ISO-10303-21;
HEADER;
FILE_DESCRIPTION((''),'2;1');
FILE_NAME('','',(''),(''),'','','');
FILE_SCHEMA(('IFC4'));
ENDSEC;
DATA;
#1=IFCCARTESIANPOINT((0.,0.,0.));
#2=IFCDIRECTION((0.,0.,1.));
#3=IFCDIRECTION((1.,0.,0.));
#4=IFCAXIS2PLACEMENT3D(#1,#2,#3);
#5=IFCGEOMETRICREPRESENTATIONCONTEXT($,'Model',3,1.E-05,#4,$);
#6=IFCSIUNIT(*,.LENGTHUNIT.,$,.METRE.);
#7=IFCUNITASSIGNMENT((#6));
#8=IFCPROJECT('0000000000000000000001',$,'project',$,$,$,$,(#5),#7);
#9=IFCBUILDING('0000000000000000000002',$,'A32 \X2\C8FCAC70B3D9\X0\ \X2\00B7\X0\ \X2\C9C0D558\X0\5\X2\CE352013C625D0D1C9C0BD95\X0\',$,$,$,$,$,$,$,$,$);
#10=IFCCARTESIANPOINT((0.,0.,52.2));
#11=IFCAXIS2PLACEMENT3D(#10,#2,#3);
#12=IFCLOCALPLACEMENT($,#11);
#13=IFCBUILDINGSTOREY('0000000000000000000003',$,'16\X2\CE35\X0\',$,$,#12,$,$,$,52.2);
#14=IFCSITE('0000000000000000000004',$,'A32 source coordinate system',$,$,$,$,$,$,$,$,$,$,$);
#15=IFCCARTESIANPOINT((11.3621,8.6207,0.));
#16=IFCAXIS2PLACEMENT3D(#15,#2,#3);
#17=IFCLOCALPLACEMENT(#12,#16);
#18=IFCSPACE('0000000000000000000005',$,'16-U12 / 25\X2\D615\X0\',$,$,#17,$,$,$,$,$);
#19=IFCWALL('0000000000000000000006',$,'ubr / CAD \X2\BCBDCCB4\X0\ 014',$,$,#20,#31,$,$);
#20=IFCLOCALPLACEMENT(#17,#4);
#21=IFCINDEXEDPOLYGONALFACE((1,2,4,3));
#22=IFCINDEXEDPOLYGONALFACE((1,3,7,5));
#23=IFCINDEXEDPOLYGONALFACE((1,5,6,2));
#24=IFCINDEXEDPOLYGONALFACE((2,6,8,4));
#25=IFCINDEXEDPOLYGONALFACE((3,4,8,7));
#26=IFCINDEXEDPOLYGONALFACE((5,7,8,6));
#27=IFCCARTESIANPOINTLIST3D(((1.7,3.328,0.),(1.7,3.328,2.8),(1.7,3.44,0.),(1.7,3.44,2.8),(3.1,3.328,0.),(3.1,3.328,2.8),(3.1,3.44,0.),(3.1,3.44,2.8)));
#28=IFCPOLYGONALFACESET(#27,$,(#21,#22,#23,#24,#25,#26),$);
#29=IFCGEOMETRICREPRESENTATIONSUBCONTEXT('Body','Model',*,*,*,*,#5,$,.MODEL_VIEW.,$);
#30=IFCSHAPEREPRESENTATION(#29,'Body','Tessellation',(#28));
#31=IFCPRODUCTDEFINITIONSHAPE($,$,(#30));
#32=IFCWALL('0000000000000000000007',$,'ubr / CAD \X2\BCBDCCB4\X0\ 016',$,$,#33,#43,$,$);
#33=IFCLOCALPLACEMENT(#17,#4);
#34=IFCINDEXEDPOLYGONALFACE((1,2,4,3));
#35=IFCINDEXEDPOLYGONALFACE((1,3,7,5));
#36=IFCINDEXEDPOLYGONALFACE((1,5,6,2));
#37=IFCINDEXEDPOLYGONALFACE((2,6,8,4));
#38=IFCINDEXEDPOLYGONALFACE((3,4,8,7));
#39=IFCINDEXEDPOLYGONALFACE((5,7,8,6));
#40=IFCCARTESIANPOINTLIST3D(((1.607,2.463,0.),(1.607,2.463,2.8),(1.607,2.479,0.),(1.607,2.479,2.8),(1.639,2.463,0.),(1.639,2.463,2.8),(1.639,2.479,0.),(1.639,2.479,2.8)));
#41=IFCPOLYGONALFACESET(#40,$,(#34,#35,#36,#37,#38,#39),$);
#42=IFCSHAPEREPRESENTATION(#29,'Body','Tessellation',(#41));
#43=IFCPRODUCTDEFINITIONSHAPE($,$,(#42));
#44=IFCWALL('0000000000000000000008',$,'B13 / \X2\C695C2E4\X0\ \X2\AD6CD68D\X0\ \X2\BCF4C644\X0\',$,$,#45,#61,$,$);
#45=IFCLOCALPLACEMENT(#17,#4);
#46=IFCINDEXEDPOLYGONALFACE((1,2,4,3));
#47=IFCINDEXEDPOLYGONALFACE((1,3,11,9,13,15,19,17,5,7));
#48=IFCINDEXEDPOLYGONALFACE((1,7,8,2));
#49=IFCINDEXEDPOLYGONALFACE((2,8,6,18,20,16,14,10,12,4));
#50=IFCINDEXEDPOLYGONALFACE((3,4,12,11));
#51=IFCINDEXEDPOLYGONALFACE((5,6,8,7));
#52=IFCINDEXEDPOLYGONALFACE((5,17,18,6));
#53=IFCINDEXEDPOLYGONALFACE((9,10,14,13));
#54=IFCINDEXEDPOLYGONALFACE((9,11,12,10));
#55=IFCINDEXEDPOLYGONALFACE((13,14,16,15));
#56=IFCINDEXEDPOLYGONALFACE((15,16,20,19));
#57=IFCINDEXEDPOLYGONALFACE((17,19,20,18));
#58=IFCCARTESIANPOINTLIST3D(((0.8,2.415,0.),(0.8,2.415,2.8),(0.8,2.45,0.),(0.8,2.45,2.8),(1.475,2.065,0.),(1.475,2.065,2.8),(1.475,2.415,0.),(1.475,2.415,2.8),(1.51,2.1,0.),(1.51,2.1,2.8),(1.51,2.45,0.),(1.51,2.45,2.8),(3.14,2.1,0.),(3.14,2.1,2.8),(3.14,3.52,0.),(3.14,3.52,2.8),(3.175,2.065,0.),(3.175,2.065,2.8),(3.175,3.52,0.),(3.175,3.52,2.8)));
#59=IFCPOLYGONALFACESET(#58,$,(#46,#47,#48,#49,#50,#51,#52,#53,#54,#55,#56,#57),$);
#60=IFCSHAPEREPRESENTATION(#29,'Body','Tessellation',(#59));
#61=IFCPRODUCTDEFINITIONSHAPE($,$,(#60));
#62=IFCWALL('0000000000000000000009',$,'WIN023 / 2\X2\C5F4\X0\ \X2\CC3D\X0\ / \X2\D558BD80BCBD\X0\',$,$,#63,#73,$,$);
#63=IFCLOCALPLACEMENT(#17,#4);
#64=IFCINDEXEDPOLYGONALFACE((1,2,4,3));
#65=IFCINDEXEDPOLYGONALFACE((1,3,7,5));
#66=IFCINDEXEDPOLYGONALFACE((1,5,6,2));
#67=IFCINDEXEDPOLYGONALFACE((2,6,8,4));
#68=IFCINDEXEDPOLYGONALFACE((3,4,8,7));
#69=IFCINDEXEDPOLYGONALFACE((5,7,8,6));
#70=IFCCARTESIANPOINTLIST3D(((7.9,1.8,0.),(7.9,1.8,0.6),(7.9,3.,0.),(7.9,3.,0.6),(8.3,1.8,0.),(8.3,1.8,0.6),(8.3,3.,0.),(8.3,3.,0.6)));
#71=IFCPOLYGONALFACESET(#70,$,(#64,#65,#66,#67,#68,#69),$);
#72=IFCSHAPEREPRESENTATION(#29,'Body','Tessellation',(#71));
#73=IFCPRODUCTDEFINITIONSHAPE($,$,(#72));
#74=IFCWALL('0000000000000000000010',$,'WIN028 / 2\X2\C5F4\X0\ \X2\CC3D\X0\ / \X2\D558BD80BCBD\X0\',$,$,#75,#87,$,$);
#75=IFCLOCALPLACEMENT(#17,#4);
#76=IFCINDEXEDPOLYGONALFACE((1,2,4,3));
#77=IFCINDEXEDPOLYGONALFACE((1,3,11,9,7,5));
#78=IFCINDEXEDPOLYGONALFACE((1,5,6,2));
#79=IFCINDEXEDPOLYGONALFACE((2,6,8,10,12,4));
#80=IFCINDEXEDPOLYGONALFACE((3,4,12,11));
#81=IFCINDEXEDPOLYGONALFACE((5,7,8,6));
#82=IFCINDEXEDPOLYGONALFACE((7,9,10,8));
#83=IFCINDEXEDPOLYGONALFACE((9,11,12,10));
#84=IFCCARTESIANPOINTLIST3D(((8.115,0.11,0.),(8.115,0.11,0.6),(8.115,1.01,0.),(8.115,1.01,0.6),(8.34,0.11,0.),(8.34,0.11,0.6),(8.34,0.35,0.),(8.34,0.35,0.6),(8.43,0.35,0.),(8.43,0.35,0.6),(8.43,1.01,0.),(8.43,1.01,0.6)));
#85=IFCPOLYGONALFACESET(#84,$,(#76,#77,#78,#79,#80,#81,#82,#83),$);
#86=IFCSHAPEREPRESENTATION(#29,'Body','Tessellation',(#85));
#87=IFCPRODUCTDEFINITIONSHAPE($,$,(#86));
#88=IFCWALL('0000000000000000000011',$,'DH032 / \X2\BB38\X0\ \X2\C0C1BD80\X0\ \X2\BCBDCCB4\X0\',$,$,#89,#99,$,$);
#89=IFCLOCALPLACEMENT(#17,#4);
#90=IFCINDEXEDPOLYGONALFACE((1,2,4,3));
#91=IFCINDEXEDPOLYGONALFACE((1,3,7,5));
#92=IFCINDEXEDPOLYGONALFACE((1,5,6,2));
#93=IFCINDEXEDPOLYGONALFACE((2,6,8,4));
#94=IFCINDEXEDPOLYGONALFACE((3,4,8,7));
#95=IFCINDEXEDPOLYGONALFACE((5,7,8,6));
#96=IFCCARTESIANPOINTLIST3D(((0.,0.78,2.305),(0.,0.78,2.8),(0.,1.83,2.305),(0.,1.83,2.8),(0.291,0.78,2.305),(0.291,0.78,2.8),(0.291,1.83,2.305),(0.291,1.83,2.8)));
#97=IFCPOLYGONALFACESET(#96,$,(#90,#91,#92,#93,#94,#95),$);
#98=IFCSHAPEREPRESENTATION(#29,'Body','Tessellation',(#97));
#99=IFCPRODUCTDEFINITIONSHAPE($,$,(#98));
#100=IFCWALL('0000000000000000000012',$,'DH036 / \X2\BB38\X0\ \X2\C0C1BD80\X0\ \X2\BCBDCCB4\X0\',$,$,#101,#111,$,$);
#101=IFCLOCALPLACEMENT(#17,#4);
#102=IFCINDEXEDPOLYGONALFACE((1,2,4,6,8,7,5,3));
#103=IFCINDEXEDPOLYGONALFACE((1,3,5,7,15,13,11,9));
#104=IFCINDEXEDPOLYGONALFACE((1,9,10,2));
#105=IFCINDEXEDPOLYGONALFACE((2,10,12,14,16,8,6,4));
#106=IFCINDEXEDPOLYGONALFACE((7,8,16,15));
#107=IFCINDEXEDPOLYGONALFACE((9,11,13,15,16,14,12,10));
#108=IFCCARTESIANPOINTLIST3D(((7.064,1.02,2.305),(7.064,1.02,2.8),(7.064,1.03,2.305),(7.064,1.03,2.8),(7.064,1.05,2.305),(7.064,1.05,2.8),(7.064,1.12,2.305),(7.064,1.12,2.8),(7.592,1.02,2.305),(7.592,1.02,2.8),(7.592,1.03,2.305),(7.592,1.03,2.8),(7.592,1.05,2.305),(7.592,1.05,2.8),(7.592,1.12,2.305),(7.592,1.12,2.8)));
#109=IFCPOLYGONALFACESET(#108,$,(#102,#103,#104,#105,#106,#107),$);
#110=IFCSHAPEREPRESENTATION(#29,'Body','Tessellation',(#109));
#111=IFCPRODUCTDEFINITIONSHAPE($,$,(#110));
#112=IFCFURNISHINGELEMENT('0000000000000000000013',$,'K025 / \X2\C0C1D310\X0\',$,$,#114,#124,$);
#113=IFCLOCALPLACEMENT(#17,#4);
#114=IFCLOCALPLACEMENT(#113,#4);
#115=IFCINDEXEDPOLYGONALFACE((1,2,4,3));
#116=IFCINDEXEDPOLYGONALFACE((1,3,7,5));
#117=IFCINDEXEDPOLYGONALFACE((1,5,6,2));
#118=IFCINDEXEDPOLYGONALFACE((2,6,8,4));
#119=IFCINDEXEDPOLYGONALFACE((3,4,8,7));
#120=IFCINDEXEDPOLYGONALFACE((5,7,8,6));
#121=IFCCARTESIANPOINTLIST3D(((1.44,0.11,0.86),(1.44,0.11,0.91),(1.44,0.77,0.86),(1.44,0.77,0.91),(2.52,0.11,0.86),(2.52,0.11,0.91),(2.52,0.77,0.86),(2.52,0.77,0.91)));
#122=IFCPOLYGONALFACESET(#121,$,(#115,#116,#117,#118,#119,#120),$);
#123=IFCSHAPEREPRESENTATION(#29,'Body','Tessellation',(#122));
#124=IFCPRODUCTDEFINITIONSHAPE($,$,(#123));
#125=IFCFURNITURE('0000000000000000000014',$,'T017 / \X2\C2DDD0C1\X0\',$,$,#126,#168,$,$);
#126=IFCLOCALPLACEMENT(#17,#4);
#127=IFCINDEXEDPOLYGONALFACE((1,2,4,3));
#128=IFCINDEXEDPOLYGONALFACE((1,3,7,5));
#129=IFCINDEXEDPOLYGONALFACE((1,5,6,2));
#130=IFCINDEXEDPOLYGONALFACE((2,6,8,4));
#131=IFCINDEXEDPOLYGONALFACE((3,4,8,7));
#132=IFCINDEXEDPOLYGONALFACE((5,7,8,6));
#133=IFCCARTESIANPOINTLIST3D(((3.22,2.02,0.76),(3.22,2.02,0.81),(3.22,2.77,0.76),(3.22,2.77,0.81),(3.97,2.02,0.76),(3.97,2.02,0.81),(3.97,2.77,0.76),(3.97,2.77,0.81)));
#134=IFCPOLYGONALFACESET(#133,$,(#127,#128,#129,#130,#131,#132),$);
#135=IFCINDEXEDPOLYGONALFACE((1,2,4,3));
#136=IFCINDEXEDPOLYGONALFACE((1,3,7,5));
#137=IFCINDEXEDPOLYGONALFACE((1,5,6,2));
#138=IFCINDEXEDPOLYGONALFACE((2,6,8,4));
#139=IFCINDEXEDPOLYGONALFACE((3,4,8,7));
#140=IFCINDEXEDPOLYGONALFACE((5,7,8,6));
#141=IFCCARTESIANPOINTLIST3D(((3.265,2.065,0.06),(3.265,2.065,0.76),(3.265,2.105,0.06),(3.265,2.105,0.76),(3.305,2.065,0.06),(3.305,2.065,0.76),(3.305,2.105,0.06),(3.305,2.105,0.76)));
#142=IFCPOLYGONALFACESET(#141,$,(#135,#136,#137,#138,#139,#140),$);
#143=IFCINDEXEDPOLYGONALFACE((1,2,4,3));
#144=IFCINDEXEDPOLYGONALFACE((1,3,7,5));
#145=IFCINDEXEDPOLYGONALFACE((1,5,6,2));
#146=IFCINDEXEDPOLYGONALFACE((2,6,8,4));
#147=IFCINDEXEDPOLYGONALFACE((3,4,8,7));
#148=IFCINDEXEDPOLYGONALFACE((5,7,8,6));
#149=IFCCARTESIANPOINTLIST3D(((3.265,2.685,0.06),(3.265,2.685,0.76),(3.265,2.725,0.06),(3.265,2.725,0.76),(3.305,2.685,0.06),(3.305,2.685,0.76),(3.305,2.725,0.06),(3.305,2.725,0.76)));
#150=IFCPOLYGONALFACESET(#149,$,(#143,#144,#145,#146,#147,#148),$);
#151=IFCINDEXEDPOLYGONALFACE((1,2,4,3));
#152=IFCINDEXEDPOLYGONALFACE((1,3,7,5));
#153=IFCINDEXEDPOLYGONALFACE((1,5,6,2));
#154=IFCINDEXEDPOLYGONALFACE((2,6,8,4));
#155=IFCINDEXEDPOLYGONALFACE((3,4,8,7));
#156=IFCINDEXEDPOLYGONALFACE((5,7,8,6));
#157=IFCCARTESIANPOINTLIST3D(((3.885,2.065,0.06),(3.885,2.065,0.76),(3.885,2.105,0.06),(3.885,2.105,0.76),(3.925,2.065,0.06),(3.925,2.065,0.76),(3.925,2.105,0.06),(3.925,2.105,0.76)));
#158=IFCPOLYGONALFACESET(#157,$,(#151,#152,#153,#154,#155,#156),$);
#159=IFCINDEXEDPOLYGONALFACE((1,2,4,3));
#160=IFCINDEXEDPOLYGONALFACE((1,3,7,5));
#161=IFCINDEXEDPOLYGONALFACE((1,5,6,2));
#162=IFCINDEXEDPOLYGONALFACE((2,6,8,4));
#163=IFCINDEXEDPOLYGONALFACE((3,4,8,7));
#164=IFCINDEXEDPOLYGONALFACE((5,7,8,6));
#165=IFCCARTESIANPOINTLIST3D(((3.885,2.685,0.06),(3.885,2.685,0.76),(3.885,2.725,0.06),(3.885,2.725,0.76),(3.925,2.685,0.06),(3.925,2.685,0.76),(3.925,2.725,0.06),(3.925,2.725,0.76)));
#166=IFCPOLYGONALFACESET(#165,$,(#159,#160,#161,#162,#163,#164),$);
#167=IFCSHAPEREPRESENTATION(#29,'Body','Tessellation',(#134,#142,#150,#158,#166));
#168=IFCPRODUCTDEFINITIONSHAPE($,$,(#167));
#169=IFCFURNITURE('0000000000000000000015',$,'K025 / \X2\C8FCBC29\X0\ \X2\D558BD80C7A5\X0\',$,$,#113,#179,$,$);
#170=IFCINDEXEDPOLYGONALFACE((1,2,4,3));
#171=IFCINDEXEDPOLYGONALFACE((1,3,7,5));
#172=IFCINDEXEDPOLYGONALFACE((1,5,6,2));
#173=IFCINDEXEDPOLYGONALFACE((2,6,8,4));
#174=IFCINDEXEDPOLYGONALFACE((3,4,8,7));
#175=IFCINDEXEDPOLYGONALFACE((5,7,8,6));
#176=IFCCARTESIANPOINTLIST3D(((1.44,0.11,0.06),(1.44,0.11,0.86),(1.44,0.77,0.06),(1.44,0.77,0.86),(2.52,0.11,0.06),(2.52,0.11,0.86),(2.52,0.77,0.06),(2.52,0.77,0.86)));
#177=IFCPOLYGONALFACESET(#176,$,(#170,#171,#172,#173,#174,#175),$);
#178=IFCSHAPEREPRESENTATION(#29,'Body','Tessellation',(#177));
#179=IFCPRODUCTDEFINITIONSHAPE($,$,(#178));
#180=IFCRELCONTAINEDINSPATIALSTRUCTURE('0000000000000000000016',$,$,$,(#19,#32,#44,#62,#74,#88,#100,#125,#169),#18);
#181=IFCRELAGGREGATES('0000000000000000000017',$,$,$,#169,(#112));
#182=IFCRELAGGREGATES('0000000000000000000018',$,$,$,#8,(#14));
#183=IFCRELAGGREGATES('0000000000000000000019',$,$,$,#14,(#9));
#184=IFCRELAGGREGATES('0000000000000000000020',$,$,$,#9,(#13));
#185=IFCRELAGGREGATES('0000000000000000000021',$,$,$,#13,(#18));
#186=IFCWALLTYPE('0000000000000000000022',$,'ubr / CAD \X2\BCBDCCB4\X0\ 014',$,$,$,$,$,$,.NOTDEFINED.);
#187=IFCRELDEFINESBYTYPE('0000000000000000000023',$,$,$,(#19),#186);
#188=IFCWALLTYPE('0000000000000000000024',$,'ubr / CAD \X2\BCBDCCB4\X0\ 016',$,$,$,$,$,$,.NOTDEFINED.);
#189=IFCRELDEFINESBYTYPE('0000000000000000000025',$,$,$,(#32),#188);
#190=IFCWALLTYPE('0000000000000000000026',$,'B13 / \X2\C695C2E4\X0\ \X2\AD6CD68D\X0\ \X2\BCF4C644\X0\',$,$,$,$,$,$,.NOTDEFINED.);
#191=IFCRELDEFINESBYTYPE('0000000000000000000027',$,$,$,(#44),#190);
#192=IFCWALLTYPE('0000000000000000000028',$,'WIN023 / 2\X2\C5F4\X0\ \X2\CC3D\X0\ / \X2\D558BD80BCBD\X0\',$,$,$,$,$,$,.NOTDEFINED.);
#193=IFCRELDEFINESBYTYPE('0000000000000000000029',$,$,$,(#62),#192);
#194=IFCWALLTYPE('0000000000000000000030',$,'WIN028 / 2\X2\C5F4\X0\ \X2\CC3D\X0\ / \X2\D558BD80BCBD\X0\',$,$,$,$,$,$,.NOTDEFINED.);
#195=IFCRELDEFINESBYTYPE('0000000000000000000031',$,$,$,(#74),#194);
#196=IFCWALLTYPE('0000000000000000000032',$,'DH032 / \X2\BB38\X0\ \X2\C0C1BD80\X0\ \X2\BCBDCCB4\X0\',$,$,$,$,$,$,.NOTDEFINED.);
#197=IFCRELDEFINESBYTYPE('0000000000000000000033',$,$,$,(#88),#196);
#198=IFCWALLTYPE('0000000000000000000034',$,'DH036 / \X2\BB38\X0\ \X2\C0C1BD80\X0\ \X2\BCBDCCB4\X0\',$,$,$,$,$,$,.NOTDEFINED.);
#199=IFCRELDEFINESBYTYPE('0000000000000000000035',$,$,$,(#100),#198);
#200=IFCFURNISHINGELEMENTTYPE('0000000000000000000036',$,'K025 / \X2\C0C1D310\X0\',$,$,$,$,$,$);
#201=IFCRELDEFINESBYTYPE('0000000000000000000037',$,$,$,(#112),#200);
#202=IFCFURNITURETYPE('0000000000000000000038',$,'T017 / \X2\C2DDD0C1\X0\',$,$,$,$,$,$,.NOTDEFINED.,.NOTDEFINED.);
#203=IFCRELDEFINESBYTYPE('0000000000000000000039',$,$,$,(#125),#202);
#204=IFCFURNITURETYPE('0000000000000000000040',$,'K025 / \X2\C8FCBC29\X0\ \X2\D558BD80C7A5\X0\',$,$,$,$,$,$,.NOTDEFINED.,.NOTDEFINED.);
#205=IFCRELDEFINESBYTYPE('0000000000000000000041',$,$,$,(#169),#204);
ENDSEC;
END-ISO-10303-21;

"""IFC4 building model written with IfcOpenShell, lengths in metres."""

from ifc_helpers import new_model, si_unit, frame, origin, origin_with_axes, place, context, subcontext, project, spatial, polyline, outline, extrude, source, transform, mapped, type_object, type_shapes, element, aggregate, save


model = new_model("IFC4")

# Units and contexts
model_context = context("Model", 3, precision=1e-05, world=origin_with_axes())
body_context = subcontext(model_context, "Body", "Model", "MODEL_VIEW")
ifc_project = project(units=[si_unit("LENGTHUNIT", "METRE")], contexts=[model_context])

# Site, building, storey, space
site = spatial("IfcSite", under=ifc_project, Name="A32 source coordinate system")
building = spatial("IfcBuilding", under=site, Name="A32 주거동 · 지하5층–옥탑지붕")
storey_placement = place(None, frame((0.0, 0.0, 52.2), z_axis=(0.0, 0.0, 1.0), x_axis=(1.0, 0.0, 0.0)))
storey = spatial("IfcBuildingStorey", under=building, at=storey_placement, Name="16층", Elevation=52.2)
space_1_placement = place(storey_placement, frame((11.3621, 8.6207, 0.0), z_axis=(0.0, 0.0, 1.0), x_axis=(1.0, 0.0, 0.0)))
space_1 = spatial("IfcSpace", under=storey, at=space_1_placement, Name="16-U12 / 25형")

# Walls
wall_type_1 = type_object("IfcWallType", Name="ubr / CAD 벽체 014", PredefinedType="NOTDEFINED")
shared_shape_1 = source(origin(), body_context, "Body", "SweptSolid", [
    extrude(outline(polyline([(3.1, 3.44), (3.1, 3.328), (1.7, 3.328), (1.7, 3.44), (3.1, 3.44)])), origin(), (0.0, 0.0, 1.0), 2.8),
])
type_shapes(wall_type_1, [shared_shape_1])
wall_1_placement = place(space_1_placement, origin_with_axes())
element("IfcWall", 1, at=wall_1_placement, inside=space_1, type_object=wall_type_1, Name="ubr / CAD 벽체 014", context=body_context, shape_type="MappedRepresentation", body=[
    mapped(shared_shape_1, transform((0.0, 0.0, 0.0), scale=1.0)),
])
wall_type_2 = type_object("IfcWallType", Name="ubr / CAD 벽체 016", PredefinedType="NOTDEFINED")
shared_shape_2 = source(origin(), body_context, "Body", "SweptSolid", [
    extrude(outline(polyline([(1.639, 2.479), (1.639, 2.463), (1.607, 2.463), (1.607, 2.479), (1.639, 2.479)])), origin(), (0.0, 0.0, 1.0), 2.8),
])
type_shapes(wall_type_2, [shared_shape_2])
wall_2_placement = place(space_1_placement, origin_with_axes())
element("IfcWall", 2, at=wall_2_placement, inside=space_1, type_object=wall_type_2, Name="ubr / CAD 벽체 016", context=body_context, shape_type="MappedRepresentation", body=[
    mapped(shared_shape_2, transform((0.0, 0.0, 0.0), scale=1.0)),
])
wall_type_3 = type_object("IfcWallType", Name="B13 / 욕실 구획 보완", PredefinedType="NOTDEFINED")
shared_shape_3 = source(origin(), body_context, "Body", "SweptSolid", [
    extrude(outline(polyline([(0.8, 2.45), (1.51, 2.45), (1.51, 2.1), (3.14, 2.1), (3.14, 3.52), (3.175, 3.52), (3.175, 2.065), (1.475, 2.065), (1.475, 2.415), (0.8, 2.415), (0.8, 2.45)])), origin(), (0.0, 0.0, 1.0), 2.8),
])
type_shapes(wall_type_3, [shared_shape_3])
wall_3_placement = place(space_1_placement, origin_with_axes())
element("IfcWall", 3, at=wall_3_placement, inside=space_1, type_object=wall_type_3, Name="B13 / 욕실 구획 보완", context=body_context, shape_type="MappedRepresentation", body=[
    mapped(shared_shape_3, transform((0.0, 0.0, 0.0), scale=1.0)),
])
wall_type_4 = type_object("IfcWallType", Name="WIN023 / 2열 창 / 하부벽", PredefinedType="NOTDEFINED")
shared_shape_4 = source(origin(), body_context, "Body", "SweptSolid", [
    extrude(outline(polyline([(7.9, 1.8), (7.9, 3.0), (8.3, 3.0), (8.3, 1.8), (7.9, 1.8)])), origin(), (0.0, 0.0, 1.0), 0.6),
])
type_shapes(wall_type_4, [shared_shape_4])
wall_4_placement = place(space_1_placement, origin_with_axes())
element("IfcWall", 4, at=wall_4_placement, inside=space_1, type_object=wall_type_4, Name="WIN023 / 2열 창 / 하부벽", context=body_context, shape_type="MappedRepresentation", body=[
    mapped(shared_shape_4, transform((0.0, 0.0, 0.0), scale=1.0)),
])
wall_type_5 = type_object("IfcWallType", Name="WIN028 / 2열 창 / 하부벽", PredefinedType="NOTDEFINED")
shared_shape_5 = source(origin(), body_context, "Body", "SweptSolid", [
    extrude(outline(polyline([(8.34, 0.35), (8.34, 0.11), (8.115, 0.11), (8.115, 1.01), (8.43, 1.01), (8.43, 0.35), (8.34, 0.35)])), origin(), (0.0, 0.0, 1.0), 0.6),
])
type_shapes(wall_type_5, [shared_shape_5])
wall_5_placement = place(space_1_placement, origin_with_axes())
element("IfcWall", 5, at=wall_5_placement, inside=space_1, type_object=wall_type_5, Name="WIN028 / 2열 창 / 하부벽", context=body_context, shape_type="MappedRepresentation", body=[
    mapped(shared_shape_5, transform((0.0, 0.0, 0.0), scale=1.0)),
])
wall_type_6 = type_object("IfcWallType", Name="DH032 / 문 상부 벽체", PredefinedType="NOTDEFINED")
shared_shape_6 = source(origin(), body_context, "Body", "SweptSolid", [
    extrude(outline(polyline([(0.0, 1.83), (0.291, 1.83), (0.291, 0.78), (0.0, 0.78), (0.0, 1.83)])), frame((0.0, 0.0, 2.305)), (0.0, 0.0, 1.0), 0.495),
])
type_shapes(wall_type_6, [shared_shape_6])
wall_6_placement = place(space_1_placement, origin_with_axes())
element("IfcWall", 6, at=wall_6_placement, inside=space_1, type_object=wall_type_6, Name="DH032 / 문 상부 벽체", context=body_context, shape_type="MappedRepresentation", body=[
    mapped(shared_shape_6, transform((0.0, 0.0, 0.0), scale=1.0)),
])
wall_type_7 = type_object("IfcWallType", Name="DH036 / 문 상부 벽체", PredefinedType="NOTDEFINED")
shared_shape_7 = source(origin(), body_context, "Body", "SweptSolid", [
    extrude(outline(polyline([(7.064, 1.03), (7.064, 1.05), (7.064, 1.12), (7.592, 1.12), (7.592, 1.05), (7.592, 1.03), (7.592, 1.02), (7.064, 1.02), (7.064, 1.03)])), frame((0.0, 0.0, 2.305)), (0.0, 0.0, 1.0), 0.495),
])
type_shapes(wall_type_7, [shared_shape_7])
wall_7_placement = place(space_1_placement, origin_with_axes())
element("IfcWall", 7, at=wall_7_placement, inside=space_1, type_object=wall_type_7, Name="DH036 / 문 상부 벽체", context=body_context, shape_type="MappedRepresentation", body=[
    mapped(shared_shape_7, transform((0.0, 0.0, 0.0), scale=1.0)),
])

# Furnishing element
furnishing_element_type_1 = type_object("IfcFurnishingElementType", Name="K025 / 상판")
shared_shape_8 = source(origin(), body_context, "Body", "SweptSolid", [
    extrude(outline(polyline([(2.52, 0.77), (2.52, 0.11), (1.44, 0.11), (1.44, 0.77), (2.52, 0.77)])), frame((0.0, 0.0, 0.86)), (0.0, 0.0, 1.0), 0.05),
])
type_shapes(furnishing_element_type_1, [shared_shape_8])
furniture_1_placement = place(space_1_placement, origin_with_axes())
furnishing_1_placement = place(furniture_1_placement, origin_with_axes())
furnishing_1 = element("IfcFurnishingElement", 8, at=furnishing_1_placement, type_object=furnishing_element_type_1, Name="K025 / 상판", context=body_context, shape_type="MappedRepresentation", body=[
    mapped(shared_shape_8, transform((0.0, 0.0, 0.0), scale=1.0)),
])

# Furniture
furniture_type_1 = type_object("IfcFurnitureType", Name="T017 / 식탁", AssemblyPlace="NOTDEFINED", PredefinedType="NOTDEFINED")
shared_shape_9 = source(origin(), body_context, "Body", "SweptSolid", [
    extrude(outline(polyline([(3.97, 2.02), (3.22, 2.02), (3.22, 2.77), (3.97, 2.77), (3.97, 2.02)])), frame((0.0, 0.0, 0.76)), (0.0, 0.0, 1.0), 0.05),
    extrude(outline(polyline([(3.265, 2.065), (3.265, 2.105), (3.305, 2.105), (3.305, 2.065), (3.265, 2.065)])), frame((0.0, 0.0, 0.06)), (0.0, 0.0, 1.0), 0.7),
    extrude(outline(polyline([(3.265, 2.685), (3.265, 2.725), (3.305, 2.725), (3.305, 2.685), (3.265, 2.685)])), frame((0.0, 0.0, 0.06)), (0.0, 0.0, 1.0), 0.7),
    extrude(outline(polyline([(3.885, 2.065), (3.885, 2.105), (3.925, 2.105), (3.925, 2.065), (3.885, 2.065)])), frame((0.0, 0.0, 0.06)), (0.0, 0.0, 1.0), 0.7),
    extrude(outline(polyline([(3.885, 2.685), (3.885, 2.725), (3.925, 2.725), (3.925, 2.685), (3.885, 2.685)])), frame((0.0, 0.0, 0.06)), (0.0, 0.0, 1.0), 0.7),
])
type_shapes(furniture_type_1, [shared_shape_9])
furniture_2_placement = place(space_1_placement, origin_with_axes())
element("IfcFurniture", 9, at=furniture_2_placement, inside=space_1, type_object=furniture_type_1, Name="T017 / 식탁", context=body_context, shape_type="MappedRepresentation", body=[
    mapped(shared_shape_9, transform((0.0, 0.0, 0.0), scale=1.0)),
])
furniture_type_2 = type_object("IfcFurnitureType", Name="K025 / 주방 하부장", AssemblyPlace="NOTDEFINED", PredefinedType="NOTDEFINED")
shared_shape_10 = source(origin(), body_context, "Body", "SweptSolid", [
    extrude(outline(polyline([(1.44, 0.77), (2.52, 0.77), (2.52, 0.11), (1.44, 0.11), (1.44, 0.77)])), frame((0.0, 0.0, 0.06)), (0.0, 0.0, 1.0), 0.8),
])
type_shapes(furniture_type_2, [shared_shape_10])
furniture_1 = element("IfcFurniture", 10, at=furniture_1_placement, inside=space_1, type_object=furniture_type_2, Name="K025 / 주방 하부장", context=body_context, shape_type="MappedRepresentation", body=[
    mapped(shared_shape_10, transform((0.0, 0.0, 0.0), scale=1.0)),
])
aggregate(furniture_1, [furnishing_1])

save(model, "model.ifc")
